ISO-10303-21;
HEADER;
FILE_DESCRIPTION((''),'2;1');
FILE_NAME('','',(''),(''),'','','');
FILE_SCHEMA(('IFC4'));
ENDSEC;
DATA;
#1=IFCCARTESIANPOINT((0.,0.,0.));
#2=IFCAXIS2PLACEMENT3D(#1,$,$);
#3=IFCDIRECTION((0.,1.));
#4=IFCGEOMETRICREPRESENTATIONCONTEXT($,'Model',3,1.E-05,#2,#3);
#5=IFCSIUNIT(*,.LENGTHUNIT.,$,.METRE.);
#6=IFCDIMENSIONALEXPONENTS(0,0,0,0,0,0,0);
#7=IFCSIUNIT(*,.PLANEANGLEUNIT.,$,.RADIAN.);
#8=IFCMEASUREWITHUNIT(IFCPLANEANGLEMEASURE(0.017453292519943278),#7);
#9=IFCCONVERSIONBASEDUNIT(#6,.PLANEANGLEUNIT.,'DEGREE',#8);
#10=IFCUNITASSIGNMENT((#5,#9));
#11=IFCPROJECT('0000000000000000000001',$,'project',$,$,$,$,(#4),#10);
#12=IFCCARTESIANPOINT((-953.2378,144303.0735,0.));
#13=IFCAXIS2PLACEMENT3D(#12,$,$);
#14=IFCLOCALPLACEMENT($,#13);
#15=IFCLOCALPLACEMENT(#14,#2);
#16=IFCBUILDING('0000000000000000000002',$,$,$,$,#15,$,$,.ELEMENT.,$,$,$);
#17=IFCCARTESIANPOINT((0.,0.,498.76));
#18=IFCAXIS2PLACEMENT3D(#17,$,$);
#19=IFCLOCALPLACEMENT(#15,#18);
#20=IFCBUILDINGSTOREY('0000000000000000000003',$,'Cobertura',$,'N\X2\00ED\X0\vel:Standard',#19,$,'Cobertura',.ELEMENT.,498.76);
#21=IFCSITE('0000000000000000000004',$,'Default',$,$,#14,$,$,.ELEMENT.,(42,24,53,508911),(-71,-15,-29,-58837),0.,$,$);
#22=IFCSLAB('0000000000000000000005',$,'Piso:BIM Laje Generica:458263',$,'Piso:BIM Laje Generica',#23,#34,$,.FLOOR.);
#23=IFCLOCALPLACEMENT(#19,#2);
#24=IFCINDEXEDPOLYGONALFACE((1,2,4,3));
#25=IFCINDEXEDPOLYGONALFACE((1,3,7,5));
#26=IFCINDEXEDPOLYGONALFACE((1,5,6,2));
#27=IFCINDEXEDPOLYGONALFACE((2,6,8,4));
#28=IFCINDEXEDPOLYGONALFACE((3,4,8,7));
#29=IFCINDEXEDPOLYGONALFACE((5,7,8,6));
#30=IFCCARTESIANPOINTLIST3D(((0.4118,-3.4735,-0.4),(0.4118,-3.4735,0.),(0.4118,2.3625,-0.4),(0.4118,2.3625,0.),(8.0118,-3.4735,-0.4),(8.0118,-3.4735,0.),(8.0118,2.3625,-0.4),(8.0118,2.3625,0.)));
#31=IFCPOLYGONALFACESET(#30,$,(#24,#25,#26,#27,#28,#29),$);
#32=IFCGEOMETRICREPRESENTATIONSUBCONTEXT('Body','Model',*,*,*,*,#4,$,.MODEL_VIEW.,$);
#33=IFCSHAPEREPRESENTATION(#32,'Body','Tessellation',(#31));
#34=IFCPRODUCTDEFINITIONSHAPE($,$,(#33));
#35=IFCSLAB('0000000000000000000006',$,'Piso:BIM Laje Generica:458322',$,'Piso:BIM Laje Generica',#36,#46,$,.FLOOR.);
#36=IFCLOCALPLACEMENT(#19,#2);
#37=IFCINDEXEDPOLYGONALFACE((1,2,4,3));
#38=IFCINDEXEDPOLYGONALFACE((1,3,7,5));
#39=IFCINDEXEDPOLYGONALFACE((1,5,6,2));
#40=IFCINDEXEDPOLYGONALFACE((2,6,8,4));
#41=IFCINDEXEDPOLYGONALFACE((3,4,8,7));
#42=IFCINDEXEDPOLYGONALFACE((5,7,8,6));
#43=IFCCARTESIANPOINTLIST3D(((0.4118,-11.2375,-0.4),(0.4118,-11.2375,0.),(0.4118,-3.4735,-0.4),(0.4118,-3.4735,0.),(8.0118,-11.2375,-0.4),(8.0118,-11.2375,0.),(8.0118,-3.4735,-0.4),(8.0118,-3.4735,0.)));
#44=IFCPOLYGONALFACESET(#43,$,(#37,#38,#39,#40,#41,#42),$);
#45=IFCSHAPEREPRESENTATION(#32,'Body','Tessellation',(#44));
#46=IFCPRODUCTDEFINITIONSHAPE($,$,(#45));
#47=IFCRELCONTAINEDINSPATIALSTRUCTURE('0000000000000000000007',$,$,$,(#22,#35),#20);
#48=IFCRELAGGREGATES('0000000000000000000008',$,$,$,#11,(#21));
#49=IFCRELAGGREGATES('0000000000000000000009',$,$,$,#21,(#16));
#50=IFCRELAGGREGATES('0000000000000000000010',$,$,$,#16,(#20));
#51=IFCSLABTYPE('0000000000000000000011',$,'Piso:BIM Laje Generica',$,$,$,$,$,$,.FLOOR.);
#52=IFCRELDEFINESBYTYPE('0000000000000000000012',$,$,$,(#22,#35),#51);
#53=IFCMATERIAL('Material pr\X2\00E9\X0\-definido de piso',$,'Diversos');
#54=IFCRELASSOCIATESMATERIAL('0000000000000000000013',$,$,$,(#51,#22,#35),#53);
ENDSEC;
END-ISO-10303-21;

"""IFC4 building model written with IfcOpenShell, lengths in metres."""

from ifc_helpers import new_model, entity, si_unit, converted_unit, direction, frame, origin, place, context, subcontext, project, spatial, indexed_curve, outline, extrude, material, type_object, element, save


model = new_model("IFC4")

# Units and contexts
model_context = context("Model", 3, precision=1e-05, world=origin(), true_north=direction((0.0, 1.0)))
body_context = subcontext(model_context, "Body", "Model", "MODEL_VIEW")
ifc_project = project(units=[si_unit("LENGTHUNIT", "METRE"), converted_unit("PLANEANGLEUNIT", "DEGREE", entity("IfcPlaneAngleMeasure", 0.017453292519943278), si_unit("PLANEANGLEUNIT", "RADIAN"), dimensions=[0, 0, 0, 0, 0, 0, 0])], contexts=[model_context])

# Site, building, storey
site_placement = place(None, frame((-953.2378, 144303.0735, 0.0)))
site = spatial("IfcSite", under=ifc_project, at=site_placement, Name="Default", CompositionType="ELEMENT", RefLatitude=(42, 24, 53, 508911), RefLongitude=(-71, -15, -29, -58837), RefElevation=0.0)
building_placement = place(site_placement, origin())
building = spatial("IfcBuilding", under=site, at=building_placement, CompositionType="ELEMENT")
storey_placement = place(building_placement, frame((0.0, 0.0, 498.76)))
storey = spatial("IfcBuildingStorey", under=building, at=storey_placement, Name="Cobertura", ObjectType="Nível:Standard", LongName="Cobertura", CompositionType="ELEMENT", Elevation=498.76)

# Slabs
ifc_material_1 = material(Name="Material pré-definido de piso", Category="Diversos")
slab_type = type_object("IfcSlabType", Name="Piso:BIM Laje Generica", PredefinedType="FLOOR", material=ifc_material_1)
placement_1 = place(storey_placement, origin())
element("IfcSlab", 1, at=placement_1, inside=storey, type_object=slab_type, material=ifc_material_1, Name="Piso:BIM Laje Generica:458263", ObjectType="Piso:BIM Laje Generica", PredefinedType="FLOOR", context=body_context, shape_type="SweptSolid", body=[
    extrude(outline(indexed_curve([(-2.918, -3.8), (2.918, -3.8), (2.918, 3.8), (-2.918, 3.8), (-2.918, -3.8)], self_intersect=False)), frame((4.2118, -0.5555, 0.0), z_axis=(0.0, 0.0, -1.0), x_axis=(0.0, 1.0, 0.0)), (0.0, 0.0, 1.0), 0.4),
])
element("IfcSlab", 2, at=placement_1, inside=storey, type_object=slab_type, material=ifc_material_1, Name="Piso:BIM Laje Generica:458322", ObjectType="Piso:BIM Laje Generica", PredefinedType="FLOOR", context=body_context, shape_type="SweptSolid", body=[
    extrude(outline(indexed_curve([(-3.882, -3.8), (3.882, -3.8), (3.882, 3.8), (-3.882, 3.8), (-3.882, -3.8)], self_intersect=False)), frame((4.2118, -7.3555, 0.0), z_axis=(0.0, 0.0, -1.0), x_axis=(0.0, 1.0, 0.0)), (0.0, 0.0, 1.0), 0.4),
])

save(model, "model.ifc")
